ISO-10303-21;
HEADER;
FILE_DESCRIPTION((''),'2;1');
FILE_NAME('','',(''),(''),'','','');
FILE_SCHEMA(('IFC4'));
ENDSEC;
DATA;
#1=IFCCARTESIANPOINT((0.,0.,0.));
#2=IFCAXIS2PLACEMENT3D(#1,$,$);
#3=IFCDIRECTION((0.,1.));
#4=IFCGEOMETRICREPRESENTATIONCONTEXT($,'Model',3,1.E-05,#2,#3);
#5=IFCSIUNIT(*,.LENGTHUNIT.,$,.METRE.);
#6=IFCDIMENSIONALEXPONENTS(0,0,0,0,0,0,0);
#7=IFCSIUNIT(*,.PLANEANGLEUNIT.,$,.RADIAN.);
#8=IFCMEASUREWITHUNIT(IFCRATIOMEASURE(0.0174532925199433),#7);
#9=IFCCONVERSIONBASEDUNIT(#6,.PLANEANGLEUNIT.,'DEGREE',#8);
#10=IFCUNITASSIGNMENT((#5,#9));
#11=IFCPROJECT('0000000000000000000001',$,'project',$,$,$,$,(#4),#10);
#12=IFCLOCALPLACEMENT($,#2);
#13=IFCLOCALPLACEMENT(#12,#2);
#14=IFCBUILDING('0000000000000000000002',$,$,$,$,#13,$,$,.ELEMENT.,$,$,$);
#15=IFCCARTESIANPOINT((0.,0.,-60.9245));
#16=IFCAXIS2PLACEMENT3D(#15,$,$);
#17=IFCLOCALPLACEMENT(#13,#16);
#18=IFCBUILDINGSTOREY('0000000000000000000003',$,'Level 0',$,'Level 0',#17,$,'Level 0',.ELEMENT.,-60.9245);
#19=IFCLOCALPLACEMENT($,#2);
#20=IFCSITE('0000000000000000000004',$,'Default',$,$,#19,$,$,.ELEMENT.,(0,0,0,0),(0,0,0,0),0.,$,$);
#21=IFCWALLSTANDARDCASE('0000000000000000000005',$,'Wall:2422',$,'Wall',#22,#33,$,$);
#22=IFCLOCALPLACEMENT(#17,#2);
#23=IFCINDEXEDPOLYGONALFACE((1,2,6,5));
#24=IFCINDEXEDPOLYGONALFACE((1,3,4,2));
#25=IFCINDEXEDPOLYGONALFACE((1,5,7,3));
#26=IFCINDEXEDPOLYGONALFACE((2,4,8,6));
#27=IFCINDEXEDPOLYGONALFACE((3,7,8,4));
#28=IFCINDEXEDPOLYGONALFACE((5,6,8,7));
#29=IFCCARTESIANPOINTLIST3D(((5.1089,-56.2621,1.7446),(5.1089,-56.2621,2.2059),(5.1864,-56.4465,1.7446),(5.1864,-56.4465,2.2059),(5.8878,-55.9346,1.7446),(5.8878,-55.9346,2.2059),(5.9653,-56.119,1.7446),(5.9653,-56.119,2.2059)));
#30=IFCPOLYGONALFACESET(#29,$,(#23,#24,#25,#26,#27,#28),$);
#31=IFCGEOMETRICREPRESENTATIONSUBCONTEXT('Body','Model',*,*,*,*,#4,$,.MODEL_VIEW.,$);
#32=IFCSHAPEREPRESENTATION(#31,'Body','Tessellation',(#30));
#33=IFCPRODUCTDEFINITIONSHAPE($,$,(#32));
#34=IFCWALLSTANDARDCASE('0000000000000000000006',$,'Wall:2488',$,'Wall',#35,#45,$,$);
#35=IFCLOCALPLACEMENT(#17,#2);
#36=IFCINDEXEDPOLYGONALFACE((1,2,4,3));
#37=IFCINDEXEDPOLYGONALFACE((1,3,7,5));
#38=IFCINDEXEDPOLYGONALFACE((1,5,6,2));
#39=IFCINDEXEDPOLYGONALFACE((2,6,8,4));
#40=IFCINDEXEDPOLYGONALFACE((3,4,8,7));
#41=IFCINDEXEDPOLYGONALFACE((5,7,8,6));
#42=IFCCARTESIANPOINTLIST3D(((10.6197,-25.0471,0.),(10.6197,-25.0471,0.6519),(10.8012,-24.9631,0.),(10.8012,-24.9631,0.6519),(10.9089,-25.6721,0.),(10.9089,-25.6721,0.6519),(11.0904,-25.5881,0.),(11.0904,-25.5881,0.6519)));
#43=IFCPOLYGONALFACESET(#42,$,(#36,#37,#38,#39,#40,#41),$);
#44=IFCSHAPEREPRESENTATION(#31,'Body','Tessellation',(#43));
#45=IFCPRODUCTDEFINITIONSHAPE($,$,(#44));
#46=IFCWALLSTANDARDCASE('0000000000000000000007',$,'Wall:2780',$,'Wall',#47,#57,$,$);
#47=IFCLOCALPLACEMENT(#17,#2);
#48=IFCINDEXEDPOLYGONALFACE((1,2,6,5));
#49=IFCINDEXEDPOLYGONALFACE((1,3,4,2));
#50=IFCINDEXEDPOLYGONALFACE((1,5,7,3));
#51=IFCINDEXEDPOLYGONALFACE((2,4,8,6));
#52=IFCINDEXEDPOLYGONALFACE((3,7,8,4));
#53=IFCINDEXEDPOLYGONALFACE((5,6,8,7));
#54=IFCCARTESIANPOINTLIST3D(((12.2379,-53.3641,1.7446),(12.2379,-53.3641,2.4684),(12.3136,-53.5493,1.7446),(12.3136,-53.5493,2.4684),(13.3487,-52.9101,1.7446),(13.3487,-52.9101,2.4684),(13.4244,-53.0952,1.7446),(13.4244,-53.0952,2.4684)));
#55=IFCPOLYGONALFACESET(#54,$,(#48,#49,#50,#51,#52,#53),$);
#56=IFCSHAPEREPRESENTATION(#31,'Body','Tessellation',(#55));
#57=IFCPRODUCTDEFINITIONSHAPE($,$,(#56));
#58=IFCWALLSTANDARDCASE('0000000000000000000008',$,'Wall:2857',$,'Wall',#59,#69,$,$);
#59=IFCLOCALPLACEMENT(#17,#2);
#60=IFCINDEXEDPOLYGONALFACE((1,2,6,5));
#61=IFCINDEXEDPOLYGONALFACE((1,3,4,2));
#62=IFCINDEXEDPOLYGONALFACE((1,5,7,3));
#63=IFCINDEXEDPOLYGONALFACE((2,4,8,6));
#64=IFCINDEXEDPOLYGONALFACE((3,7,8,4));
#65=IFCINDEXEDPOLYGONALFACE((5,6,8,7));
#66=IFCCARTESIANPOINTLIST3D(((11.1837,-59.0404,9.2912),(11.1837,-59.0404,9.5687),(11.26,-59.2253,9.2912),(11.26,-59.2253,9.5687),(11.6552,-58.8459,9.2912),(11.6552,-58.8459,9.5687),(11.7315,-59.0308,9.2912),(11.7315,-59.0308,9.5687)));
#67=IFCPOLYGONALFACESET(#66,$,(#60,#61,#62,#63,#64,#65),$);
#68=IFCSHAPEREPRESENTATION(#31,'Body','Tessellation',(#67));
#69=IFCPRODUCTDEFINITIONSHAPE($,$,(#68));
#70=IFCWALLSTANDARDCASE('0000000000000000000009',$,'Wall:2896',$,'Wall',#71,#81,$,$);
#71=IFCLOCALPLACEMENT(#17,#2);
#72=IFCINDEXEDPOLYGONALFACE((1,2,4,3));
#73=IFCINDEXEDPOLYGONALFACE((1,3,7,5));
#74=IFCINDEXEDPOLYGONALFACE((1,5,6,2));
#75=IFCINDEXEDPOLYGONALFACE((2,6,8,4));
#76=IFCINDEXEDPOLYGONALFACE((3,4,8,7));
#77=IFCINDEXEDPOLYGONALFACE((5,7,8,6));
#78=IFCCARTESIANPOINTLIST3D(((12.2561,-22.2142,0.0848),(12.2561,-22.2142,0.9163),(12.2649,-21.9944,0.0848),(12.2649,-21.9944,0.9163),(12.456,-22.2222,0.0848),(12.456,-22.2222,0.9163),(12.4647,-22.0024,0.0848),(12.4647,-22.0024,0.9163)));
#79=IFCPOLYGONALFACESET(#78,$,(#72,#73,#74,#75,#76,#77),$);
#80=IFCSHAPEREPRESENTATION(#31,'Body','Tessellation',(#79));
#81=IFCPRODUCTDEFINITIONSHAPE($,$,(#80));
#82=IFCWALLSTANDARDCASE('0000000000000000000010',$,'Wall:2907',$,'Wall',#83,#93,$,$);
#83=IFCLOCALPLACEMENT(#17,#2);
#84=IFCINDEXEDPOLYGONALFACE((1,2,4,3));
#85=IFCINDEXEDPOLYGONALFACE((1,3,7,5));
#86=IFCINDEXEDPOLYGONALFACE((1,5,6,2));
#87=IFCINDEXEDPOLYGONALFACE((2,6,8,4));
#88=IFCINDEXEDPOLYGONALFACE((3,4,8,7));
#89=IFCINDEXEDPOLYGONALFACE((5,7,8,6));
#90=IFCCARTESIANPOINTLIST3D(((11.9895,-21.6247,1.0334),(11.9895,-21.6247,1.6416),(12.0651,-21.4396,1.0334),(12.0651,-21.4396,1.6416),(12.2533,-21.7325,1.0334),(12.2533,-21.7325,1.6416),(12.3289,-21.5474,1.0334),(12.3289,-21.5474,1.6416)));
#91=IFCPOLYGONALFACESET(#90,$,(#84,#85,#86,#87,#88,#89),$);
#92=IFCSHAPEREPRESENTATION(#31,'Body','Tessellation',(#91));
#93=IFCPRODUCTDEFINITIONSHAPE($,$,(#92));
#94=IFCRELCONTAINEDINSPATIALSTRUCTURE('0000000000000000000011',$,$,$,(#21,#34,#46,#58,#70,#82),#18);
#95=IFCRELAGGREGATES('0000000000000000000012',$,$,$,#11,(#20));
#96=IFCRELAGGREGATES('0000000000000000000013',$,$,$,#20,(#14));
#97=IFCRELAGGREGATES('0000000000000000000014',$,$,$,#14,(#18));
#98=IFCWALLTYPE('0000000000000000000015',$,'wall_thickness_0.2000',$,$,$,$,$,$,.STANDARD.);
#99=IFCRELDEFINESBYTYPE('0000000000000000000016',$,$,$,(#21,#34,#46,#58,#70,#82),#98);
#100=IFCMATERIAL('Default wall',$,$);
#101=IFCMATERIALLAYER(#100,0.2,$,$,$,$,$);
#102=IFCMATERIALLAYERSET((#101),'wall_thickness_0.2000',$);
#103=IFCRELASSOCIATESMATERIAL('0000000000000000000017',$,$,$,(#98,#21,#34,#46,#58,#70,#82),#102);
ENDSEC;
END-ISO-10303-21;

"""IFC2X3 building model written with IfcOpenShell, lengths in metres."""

from ifc_helpers import new_model, entity, si_unit, converted_unit, direction, frame, origin, place, context, subcontext, project, spatial, polyline, outline, extrude, material, layer, layer_set, layer_usage, type_object, element, save


model = new_model("IFC2X3")

# Units and contexts
model_context = context("Model", 3, precision=1e-05, world=origin(), true_north=direction((0.0, 1.0)))
body_context = subcontext(model_context, "Body", "Model", "MODEL_VIEW")
ifc_project = project(units=[si_unit("LENGTHUNIT", "METRE"), converted_unit("PLANEANGLEUNIT", "DEGREE", entity("IfcRatioMeasure", 0.0174532925199433), si_unit("PLANEANGLEUNIT", "RADIAN"), dimensions=[0, 0, 0, 0, 0, 0, 0])], contexts=[model_context])

# Site, building, storey
site_placement = place(None, origin())
site = spatial("IfcSite", under=ifc_project, at=site_placement, Name="Default", CompositionType="ELEMENT", RefLatitude=(0, 0, 0, 0), RefLongitude=(0, 0, 0, 0), RefElevation=0.0)
placement_1 = place(None, origin())
building_placement = place(placement_1, origin())
building = spatial("IfcBuilding", under=site, at=building_placement, CompositionType="ELEMENT")
storey_placement = place(building_placement, frame((0.0, 0.0, -60.9245)))
storey = spatial("IfcBuildingStorey", under=building, at=storey_placement, Name="Level 0", ObjectType="Level 0", LongName="Level 0", CompositionType="ELEMENT", Elevation=-60.9245)

# Walls
ifc_material = material(Name="Default wall")
ifc_layer = layer(ifc_material, 0.2)
ifc_layer_set = layer_set([ifc_layer], Name="wall_thickness_0.2000")
ifc_layer_usage = layer_usage(ifc_layer_set, "AXIS2", "POSITIVE", -0.1)
wall_type = type_object("IfcWallType", Name="wall_thickness_0.2000", PredefinedType="STANDARD", material=ifc_layer_set)
placement_2 = place(building_placement, frame((0.0, 0.0, -59.1799)))
wall_1_placement = place(placement_2, frame((5.1476, -56.3543, 0.0), z_axis=(0.0, 0.0, 1.0), x_axis=(0.921835, 0.387582, 0.0)))
element("IfcWallStandardCase", 1, at=wall_1_placement, inside=storey, type_object=wall_type, material=ifc_layer_usage, Name="Wall:2422", ObjectType="Wall", context=body_context, shape_type="SweptSolid", body=[
    extrude(outline(polyline([(0.845, -0.1), (0.845, 0.1), (0.0, 0.1), (0.0, -0.1), (0.845, -0.1)])), origin(), (0.0, 0.0, 1.0), 0.4613),
])
wall_2_placement = place(storey_placement, frame((10.9996, -25.6301, 0.0), z_axis=(0.0, 0.0, 1.0), x_axis=(-0.419932, 0.907556, 0.0)))
element("IfcWallStandardCase", 2, at=wall_2_placement, inside=storey, type_object=wall_type, material=ifc_layer_usage, Name="Wall:2488", ObjectType="Wall", context=body_context, shape_type="SweptSolid", body=[
    extrude(outline(polyline([(0.6887, -0.1), (0.6887, 0.1), (0.0, 0.1), (0.0, -0.1), (0.6887, -0.1)])), origin(), (0.0, 0.0, 1.0), 0.6519),
])
placement_3 = place(building_placement, frame((0.0, 0.0, -59.1799)))
wall_3_placement = place(placement_3, frame((12.2758, -53.4567, 0.0), z_axis=(0.0, 0.0, 1.0), x_axis=(0.925645, 0.378393, 0.0)))
element("IfcWallStandardCase", 3, at=wall_3_placement, inside=storey, type_object=wall_type, material=ifc_layer_usage, Name="Wall:2780", ObjectType="Wall", context=body_context, shape_type="SweptSolid", body=[
    extrude(outline(polyline([(1.2, -0.1), (1.2, 0.1), (0.0, 0.1), (0.0, -0.1), (1.2, -0.1)])), origin(), (0.0, 0.0, 1.0), 0.7238),
])
placement_4 = place(building_placement, frame((0.0, 0.0, -51.6333)))
wall_4_placement = place(placement_4, frame((11.2219, -59.1328, 0.0), z_axis=(0.0, 0.0, 1.0), x_axis=(0.924431, 0.38135, 0.0)))
element("IfcWallStandardCase", 4, at=wall_4_placement, inside=storey, type_object=wall_type, material=ifc_layer_usage, Name="Wall:2857", ObjectType="Wall", context=body_context, shape_type="SweptSolid", body=[
    extrude(outline(polyline([(0.51, -0.1), (0.51, 0.1), (0.0, 0.1), (0.0, -0.1), (0.51, -0.1)])), origin(), (0.0, 0.0, 1.0), 0.2775),
])
placement_5 = place(building_placement, frame((0.0, 0.0, -60.8397)))
wall_5_placement = place(placement_5, frame((12.3561, -22.2182, 0.0), z_axis=(0.0, 0.0, 1.0), x_axis=(0.039812, 0.999207, 0.0)))
element("IfcWallStandardCase", 5, at=wall_5_placement, inside=storey, type_object=wall_type, material=ifc_layer_usage, Name="Wall:2896", ObjectType="Wall", context=body_context, shape_type="SweptSolid", body=[
    extrude(outline(polyline([(0.22, -0.1), (0.22, 0.1), (0.0, 0.1), (0.0, -0.1), (0.22, -0.1)])), origin(), (0.0, 0.0, 1.0), 0.8315),
])
placement_6 = place(building_placement, frame((0.0, 0.0, -59.8911)))
wall_6_placement = place(placement_6, frame((12.2911, -21.6399, 0.0), z_axis=(0.0, 0.0, 1.0), x_axis=(-0.925715, 0.378223, 0.0)))
element("IfcWallStandardCase", 6, at=wall_6_placement, inside=storey, type_object=wall_type, material=ifc_layer_usage, Name="Wall:2907", ObjectType="Wall", context=body_context, shape_type="SweptSolid", body=[
    extrude(outline(polyline([(0.285, -0.1), (0.285, 0.1), (0.0, 0.1), (0.0, -0.1), (0.285, -0.1)])), origin(), (0.0, 0.0, 1.0), 0.6083),
])

save(model, "model.ifc")
